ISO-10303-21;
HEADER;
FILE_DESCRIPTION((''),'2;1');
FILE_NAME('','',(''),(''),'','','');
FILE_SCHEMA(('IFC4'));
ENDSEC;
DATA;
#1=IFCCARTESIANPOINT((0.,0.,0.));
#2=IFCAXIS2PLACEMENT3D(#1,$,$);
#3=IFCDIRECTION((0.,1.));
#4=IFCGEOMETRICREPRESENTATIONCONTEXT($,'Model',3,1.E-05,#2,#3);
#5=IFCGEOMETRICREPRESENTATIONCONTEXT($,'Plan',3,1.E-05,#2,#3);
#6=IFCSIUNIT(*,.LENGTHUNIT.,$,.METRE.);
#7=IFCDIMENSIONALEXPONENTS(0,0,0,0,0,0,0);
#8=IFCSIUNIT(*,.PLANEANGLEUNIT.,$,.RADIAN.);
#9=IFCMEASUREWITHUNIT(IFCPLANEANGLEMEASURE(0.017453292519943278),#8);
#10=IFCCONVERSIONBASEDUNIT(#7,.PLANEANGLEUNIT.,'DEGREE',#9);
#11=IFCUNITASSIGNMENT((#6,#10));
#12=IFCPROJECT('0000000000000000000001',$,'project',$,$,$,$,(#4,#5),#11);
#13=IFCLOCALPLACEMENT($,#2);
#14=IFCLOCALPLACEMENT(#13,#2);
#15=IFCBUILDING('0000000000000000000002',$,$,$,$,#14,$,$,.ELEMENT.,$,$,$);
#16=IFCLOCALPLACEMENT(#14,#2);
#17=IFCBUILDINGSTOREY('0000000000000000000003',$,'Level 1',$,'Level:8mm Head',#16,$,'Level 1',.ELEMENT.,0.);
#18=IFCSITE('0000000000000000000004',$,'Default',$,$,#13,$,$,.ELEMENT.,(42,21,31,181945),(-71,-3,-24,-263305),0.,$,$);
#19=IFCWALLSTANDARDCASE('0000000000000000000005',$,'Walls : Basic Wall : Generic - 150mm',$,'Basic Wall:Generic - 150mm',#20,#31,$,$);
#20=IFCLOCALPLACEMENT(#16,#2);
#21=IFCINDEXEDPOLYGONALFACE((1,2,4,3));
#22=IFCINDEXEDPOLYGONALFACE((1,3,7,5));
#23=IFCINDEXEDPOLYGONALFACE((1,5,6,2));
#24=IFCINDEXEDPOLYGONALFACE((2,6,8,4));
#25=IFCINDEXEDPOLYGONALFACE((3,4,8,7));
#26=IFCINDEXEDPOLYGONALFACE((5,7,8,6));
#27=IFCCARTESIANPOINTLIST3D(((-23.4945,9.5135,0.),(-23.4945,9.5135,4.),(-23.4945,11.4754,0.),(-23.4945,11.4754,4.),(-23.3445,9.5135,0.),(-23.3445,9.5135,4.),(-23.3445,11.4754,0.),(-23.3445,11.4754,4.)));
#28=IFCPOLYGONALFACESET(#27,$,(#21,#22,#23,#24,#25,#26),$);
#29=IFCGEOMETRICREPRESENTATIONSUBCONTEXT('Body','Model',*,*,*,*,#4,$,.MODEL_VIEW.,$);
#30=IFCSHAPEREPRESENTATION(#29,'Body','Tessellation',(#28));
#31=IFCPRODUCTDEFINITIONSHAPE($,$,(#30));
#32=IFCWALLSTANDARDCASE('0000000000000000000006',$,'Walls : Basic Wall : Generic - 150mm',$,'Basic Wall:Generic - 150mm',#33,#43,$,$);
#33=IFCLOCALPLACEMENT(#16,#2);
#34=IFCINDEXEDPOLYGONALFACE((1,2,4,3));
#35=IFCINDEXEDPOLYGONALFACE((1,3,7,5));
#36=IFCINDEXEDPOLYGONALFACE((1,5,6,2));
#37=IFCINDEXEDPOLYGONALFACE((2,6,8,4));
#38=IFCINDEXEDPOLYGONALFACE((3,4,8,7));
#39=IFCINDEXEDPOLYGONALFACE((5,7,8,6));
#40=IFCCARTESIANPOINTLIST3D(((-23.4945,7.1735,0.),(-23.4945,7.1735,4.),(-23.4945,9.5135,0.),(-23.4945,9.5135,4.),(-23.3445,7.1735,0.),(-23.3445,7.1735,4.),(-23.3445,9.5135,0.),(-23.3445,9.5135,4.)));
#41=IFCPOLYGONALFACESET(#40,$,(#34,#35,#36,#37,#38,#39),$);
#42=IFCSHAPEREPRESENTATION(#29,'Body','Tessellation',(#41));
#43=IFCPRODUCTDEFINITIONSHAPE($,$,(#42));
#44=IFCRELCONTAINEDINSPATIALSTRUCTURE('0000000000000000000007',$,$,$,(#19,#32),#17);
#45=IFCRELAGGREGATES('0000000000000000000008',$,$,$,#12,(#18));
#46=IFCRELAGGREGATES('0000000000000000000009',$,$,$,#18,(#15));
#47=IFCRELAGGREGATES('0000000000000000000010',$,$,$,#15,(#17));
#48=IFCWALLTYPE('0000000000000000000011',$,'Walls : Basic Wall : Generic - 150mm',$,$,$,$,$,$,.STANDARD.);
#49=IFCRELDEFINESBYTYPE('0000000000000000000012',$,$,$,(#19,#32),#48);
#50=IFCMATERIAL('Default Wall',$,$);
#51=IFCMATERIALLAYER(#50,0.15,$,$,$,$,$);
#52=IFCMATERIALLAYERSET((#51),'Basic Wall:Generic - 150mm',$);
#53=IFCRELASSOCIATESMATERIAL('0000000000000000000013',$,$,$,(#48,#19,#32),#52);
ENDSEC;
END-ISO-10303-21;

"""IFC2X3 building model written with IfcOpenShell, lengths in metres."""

from ifc_helpers import new_model, entity, si_unit, converted_unit, direction, frame, frame_2d, origin, place, context, subcontext, project, spatial, rectangle, extrude, material, layer, layer_set, layer_usage, type_object, element, save


model = new_model("IFC2X3")

# Units and contexts
model_context = context("Model", 3, precision=1e-05, world=origin(), true_north=direction((0.0, 1.0)))
plan_context = context("Plan", 3, precision=1e-05, world=origin(), true_north=direction((0.0, 1.0)))
body_context = subcontext(model_context, "Body", "Model", "MODEL_VIEW")
ifc_project = project(units=[si_unit("LENGTHUNIT", "METRE"), converted_unit("PLANEANGLEUNIT", "DEGREE", entity("IfcPlaneAngleMeasure", 0.017453292519943278), si_unit("PLANEANGLEUNIT", "RADIAN"), dimensions=[0, 0, 0, 0, 0, 0, 0])], contexts=[model_context, plan_context])

# Site, building, storey
site_placement = place(None, origin())
site = spatial("IfcSite", under=ifc_project, at=site_placement, Name="Default", CompositionType="ELEMENT", RefLatitude=(42, 21, 31, 181945), RefLongitude=(-71, -3, -24, -263305), RefElevation=0.0)
building_placement = place(site_placement, origin())
building = spatial("IfcBuilding", under=site, at=building_placement, CompositionType="ELEMENT")
storey_placement = place(building_placement, origin())
storey = spatial("IfcBuildingStorey", under=building, at=storey_placement, Name="Level 1", ObjectType="Level:8mm Head", LongName="Level 1", CompositionType="ELEMENT", Elevation=0.0)

# Walls
ifc_material = material(Name="Default Wall")
ifc_layer_1 = layer(ifc_material, 0.15)
ifc_layer_set_1 = layer_set([ifc_layer_1], Name="Basic Wall:Generic - 150mm")
ifc_layer_usage_1 = layer_usage(ifc_layer_set_1, "AXIS2", "NEGATIVE", 0.075)
wall_type_1 = type_object("IfcWallType", Name="Walls : Basic Wall : Generic - 150mm", PredefinedType="STANDARD", material=ifc_layer_set_1)
wall_1_placement = place(storey_placement, frame((-23.4195, 9.5135, 0.0), z_axis=(0.0, 0.0, 1.0), x_axis=(0.0, 1.0, 0.0)))
element("IfcWallStandardCase", 1, at=wall_1_placement, inside=storey, type_object=wall_type_1, material=ifc_layer_usage_1, Name="Walls : Basic Wall : Generic - 150mm", ObjectType="Basic Wall:Generic - 150mm", context=body_context, shape_type="SweptSolid", body=[
    extrude(rectangle(XDim=1.9619, YDim=0.15, at=frame_2d((0.981, 0.0), x_axis=(-1.0, 0.0))), origin(), (0.0, 0.0, 1.0), 4.0),
])
wall_2_placement = place(storey_placement, frame((-23.4195, 7.1735, 0.0), z_axis=(0.0, 0.0, 1.0), x_axis=(0.0, 1.0, 0.0)))
element("IfcWallStandardCase", 2, at=wall_2_placement, inside=storey, type_object=wall_type_1, material=ifc_layer_usage_1, Name="Walls : Basic Wall : Generic - 150mm", ObjectType="Basic Wall:Generic - 150mm", context=body_context, shape_type="SweptSolid", body=[
    extrude(rectangle(XDim=2.34, YDim=0.15, at=frame_2d((1.17, 0.0), x_axis=(-1.0, 0.0))), origin(), (0.0, 0.0, 1.0), 4.0),
])

save(model, "model.ifc")
